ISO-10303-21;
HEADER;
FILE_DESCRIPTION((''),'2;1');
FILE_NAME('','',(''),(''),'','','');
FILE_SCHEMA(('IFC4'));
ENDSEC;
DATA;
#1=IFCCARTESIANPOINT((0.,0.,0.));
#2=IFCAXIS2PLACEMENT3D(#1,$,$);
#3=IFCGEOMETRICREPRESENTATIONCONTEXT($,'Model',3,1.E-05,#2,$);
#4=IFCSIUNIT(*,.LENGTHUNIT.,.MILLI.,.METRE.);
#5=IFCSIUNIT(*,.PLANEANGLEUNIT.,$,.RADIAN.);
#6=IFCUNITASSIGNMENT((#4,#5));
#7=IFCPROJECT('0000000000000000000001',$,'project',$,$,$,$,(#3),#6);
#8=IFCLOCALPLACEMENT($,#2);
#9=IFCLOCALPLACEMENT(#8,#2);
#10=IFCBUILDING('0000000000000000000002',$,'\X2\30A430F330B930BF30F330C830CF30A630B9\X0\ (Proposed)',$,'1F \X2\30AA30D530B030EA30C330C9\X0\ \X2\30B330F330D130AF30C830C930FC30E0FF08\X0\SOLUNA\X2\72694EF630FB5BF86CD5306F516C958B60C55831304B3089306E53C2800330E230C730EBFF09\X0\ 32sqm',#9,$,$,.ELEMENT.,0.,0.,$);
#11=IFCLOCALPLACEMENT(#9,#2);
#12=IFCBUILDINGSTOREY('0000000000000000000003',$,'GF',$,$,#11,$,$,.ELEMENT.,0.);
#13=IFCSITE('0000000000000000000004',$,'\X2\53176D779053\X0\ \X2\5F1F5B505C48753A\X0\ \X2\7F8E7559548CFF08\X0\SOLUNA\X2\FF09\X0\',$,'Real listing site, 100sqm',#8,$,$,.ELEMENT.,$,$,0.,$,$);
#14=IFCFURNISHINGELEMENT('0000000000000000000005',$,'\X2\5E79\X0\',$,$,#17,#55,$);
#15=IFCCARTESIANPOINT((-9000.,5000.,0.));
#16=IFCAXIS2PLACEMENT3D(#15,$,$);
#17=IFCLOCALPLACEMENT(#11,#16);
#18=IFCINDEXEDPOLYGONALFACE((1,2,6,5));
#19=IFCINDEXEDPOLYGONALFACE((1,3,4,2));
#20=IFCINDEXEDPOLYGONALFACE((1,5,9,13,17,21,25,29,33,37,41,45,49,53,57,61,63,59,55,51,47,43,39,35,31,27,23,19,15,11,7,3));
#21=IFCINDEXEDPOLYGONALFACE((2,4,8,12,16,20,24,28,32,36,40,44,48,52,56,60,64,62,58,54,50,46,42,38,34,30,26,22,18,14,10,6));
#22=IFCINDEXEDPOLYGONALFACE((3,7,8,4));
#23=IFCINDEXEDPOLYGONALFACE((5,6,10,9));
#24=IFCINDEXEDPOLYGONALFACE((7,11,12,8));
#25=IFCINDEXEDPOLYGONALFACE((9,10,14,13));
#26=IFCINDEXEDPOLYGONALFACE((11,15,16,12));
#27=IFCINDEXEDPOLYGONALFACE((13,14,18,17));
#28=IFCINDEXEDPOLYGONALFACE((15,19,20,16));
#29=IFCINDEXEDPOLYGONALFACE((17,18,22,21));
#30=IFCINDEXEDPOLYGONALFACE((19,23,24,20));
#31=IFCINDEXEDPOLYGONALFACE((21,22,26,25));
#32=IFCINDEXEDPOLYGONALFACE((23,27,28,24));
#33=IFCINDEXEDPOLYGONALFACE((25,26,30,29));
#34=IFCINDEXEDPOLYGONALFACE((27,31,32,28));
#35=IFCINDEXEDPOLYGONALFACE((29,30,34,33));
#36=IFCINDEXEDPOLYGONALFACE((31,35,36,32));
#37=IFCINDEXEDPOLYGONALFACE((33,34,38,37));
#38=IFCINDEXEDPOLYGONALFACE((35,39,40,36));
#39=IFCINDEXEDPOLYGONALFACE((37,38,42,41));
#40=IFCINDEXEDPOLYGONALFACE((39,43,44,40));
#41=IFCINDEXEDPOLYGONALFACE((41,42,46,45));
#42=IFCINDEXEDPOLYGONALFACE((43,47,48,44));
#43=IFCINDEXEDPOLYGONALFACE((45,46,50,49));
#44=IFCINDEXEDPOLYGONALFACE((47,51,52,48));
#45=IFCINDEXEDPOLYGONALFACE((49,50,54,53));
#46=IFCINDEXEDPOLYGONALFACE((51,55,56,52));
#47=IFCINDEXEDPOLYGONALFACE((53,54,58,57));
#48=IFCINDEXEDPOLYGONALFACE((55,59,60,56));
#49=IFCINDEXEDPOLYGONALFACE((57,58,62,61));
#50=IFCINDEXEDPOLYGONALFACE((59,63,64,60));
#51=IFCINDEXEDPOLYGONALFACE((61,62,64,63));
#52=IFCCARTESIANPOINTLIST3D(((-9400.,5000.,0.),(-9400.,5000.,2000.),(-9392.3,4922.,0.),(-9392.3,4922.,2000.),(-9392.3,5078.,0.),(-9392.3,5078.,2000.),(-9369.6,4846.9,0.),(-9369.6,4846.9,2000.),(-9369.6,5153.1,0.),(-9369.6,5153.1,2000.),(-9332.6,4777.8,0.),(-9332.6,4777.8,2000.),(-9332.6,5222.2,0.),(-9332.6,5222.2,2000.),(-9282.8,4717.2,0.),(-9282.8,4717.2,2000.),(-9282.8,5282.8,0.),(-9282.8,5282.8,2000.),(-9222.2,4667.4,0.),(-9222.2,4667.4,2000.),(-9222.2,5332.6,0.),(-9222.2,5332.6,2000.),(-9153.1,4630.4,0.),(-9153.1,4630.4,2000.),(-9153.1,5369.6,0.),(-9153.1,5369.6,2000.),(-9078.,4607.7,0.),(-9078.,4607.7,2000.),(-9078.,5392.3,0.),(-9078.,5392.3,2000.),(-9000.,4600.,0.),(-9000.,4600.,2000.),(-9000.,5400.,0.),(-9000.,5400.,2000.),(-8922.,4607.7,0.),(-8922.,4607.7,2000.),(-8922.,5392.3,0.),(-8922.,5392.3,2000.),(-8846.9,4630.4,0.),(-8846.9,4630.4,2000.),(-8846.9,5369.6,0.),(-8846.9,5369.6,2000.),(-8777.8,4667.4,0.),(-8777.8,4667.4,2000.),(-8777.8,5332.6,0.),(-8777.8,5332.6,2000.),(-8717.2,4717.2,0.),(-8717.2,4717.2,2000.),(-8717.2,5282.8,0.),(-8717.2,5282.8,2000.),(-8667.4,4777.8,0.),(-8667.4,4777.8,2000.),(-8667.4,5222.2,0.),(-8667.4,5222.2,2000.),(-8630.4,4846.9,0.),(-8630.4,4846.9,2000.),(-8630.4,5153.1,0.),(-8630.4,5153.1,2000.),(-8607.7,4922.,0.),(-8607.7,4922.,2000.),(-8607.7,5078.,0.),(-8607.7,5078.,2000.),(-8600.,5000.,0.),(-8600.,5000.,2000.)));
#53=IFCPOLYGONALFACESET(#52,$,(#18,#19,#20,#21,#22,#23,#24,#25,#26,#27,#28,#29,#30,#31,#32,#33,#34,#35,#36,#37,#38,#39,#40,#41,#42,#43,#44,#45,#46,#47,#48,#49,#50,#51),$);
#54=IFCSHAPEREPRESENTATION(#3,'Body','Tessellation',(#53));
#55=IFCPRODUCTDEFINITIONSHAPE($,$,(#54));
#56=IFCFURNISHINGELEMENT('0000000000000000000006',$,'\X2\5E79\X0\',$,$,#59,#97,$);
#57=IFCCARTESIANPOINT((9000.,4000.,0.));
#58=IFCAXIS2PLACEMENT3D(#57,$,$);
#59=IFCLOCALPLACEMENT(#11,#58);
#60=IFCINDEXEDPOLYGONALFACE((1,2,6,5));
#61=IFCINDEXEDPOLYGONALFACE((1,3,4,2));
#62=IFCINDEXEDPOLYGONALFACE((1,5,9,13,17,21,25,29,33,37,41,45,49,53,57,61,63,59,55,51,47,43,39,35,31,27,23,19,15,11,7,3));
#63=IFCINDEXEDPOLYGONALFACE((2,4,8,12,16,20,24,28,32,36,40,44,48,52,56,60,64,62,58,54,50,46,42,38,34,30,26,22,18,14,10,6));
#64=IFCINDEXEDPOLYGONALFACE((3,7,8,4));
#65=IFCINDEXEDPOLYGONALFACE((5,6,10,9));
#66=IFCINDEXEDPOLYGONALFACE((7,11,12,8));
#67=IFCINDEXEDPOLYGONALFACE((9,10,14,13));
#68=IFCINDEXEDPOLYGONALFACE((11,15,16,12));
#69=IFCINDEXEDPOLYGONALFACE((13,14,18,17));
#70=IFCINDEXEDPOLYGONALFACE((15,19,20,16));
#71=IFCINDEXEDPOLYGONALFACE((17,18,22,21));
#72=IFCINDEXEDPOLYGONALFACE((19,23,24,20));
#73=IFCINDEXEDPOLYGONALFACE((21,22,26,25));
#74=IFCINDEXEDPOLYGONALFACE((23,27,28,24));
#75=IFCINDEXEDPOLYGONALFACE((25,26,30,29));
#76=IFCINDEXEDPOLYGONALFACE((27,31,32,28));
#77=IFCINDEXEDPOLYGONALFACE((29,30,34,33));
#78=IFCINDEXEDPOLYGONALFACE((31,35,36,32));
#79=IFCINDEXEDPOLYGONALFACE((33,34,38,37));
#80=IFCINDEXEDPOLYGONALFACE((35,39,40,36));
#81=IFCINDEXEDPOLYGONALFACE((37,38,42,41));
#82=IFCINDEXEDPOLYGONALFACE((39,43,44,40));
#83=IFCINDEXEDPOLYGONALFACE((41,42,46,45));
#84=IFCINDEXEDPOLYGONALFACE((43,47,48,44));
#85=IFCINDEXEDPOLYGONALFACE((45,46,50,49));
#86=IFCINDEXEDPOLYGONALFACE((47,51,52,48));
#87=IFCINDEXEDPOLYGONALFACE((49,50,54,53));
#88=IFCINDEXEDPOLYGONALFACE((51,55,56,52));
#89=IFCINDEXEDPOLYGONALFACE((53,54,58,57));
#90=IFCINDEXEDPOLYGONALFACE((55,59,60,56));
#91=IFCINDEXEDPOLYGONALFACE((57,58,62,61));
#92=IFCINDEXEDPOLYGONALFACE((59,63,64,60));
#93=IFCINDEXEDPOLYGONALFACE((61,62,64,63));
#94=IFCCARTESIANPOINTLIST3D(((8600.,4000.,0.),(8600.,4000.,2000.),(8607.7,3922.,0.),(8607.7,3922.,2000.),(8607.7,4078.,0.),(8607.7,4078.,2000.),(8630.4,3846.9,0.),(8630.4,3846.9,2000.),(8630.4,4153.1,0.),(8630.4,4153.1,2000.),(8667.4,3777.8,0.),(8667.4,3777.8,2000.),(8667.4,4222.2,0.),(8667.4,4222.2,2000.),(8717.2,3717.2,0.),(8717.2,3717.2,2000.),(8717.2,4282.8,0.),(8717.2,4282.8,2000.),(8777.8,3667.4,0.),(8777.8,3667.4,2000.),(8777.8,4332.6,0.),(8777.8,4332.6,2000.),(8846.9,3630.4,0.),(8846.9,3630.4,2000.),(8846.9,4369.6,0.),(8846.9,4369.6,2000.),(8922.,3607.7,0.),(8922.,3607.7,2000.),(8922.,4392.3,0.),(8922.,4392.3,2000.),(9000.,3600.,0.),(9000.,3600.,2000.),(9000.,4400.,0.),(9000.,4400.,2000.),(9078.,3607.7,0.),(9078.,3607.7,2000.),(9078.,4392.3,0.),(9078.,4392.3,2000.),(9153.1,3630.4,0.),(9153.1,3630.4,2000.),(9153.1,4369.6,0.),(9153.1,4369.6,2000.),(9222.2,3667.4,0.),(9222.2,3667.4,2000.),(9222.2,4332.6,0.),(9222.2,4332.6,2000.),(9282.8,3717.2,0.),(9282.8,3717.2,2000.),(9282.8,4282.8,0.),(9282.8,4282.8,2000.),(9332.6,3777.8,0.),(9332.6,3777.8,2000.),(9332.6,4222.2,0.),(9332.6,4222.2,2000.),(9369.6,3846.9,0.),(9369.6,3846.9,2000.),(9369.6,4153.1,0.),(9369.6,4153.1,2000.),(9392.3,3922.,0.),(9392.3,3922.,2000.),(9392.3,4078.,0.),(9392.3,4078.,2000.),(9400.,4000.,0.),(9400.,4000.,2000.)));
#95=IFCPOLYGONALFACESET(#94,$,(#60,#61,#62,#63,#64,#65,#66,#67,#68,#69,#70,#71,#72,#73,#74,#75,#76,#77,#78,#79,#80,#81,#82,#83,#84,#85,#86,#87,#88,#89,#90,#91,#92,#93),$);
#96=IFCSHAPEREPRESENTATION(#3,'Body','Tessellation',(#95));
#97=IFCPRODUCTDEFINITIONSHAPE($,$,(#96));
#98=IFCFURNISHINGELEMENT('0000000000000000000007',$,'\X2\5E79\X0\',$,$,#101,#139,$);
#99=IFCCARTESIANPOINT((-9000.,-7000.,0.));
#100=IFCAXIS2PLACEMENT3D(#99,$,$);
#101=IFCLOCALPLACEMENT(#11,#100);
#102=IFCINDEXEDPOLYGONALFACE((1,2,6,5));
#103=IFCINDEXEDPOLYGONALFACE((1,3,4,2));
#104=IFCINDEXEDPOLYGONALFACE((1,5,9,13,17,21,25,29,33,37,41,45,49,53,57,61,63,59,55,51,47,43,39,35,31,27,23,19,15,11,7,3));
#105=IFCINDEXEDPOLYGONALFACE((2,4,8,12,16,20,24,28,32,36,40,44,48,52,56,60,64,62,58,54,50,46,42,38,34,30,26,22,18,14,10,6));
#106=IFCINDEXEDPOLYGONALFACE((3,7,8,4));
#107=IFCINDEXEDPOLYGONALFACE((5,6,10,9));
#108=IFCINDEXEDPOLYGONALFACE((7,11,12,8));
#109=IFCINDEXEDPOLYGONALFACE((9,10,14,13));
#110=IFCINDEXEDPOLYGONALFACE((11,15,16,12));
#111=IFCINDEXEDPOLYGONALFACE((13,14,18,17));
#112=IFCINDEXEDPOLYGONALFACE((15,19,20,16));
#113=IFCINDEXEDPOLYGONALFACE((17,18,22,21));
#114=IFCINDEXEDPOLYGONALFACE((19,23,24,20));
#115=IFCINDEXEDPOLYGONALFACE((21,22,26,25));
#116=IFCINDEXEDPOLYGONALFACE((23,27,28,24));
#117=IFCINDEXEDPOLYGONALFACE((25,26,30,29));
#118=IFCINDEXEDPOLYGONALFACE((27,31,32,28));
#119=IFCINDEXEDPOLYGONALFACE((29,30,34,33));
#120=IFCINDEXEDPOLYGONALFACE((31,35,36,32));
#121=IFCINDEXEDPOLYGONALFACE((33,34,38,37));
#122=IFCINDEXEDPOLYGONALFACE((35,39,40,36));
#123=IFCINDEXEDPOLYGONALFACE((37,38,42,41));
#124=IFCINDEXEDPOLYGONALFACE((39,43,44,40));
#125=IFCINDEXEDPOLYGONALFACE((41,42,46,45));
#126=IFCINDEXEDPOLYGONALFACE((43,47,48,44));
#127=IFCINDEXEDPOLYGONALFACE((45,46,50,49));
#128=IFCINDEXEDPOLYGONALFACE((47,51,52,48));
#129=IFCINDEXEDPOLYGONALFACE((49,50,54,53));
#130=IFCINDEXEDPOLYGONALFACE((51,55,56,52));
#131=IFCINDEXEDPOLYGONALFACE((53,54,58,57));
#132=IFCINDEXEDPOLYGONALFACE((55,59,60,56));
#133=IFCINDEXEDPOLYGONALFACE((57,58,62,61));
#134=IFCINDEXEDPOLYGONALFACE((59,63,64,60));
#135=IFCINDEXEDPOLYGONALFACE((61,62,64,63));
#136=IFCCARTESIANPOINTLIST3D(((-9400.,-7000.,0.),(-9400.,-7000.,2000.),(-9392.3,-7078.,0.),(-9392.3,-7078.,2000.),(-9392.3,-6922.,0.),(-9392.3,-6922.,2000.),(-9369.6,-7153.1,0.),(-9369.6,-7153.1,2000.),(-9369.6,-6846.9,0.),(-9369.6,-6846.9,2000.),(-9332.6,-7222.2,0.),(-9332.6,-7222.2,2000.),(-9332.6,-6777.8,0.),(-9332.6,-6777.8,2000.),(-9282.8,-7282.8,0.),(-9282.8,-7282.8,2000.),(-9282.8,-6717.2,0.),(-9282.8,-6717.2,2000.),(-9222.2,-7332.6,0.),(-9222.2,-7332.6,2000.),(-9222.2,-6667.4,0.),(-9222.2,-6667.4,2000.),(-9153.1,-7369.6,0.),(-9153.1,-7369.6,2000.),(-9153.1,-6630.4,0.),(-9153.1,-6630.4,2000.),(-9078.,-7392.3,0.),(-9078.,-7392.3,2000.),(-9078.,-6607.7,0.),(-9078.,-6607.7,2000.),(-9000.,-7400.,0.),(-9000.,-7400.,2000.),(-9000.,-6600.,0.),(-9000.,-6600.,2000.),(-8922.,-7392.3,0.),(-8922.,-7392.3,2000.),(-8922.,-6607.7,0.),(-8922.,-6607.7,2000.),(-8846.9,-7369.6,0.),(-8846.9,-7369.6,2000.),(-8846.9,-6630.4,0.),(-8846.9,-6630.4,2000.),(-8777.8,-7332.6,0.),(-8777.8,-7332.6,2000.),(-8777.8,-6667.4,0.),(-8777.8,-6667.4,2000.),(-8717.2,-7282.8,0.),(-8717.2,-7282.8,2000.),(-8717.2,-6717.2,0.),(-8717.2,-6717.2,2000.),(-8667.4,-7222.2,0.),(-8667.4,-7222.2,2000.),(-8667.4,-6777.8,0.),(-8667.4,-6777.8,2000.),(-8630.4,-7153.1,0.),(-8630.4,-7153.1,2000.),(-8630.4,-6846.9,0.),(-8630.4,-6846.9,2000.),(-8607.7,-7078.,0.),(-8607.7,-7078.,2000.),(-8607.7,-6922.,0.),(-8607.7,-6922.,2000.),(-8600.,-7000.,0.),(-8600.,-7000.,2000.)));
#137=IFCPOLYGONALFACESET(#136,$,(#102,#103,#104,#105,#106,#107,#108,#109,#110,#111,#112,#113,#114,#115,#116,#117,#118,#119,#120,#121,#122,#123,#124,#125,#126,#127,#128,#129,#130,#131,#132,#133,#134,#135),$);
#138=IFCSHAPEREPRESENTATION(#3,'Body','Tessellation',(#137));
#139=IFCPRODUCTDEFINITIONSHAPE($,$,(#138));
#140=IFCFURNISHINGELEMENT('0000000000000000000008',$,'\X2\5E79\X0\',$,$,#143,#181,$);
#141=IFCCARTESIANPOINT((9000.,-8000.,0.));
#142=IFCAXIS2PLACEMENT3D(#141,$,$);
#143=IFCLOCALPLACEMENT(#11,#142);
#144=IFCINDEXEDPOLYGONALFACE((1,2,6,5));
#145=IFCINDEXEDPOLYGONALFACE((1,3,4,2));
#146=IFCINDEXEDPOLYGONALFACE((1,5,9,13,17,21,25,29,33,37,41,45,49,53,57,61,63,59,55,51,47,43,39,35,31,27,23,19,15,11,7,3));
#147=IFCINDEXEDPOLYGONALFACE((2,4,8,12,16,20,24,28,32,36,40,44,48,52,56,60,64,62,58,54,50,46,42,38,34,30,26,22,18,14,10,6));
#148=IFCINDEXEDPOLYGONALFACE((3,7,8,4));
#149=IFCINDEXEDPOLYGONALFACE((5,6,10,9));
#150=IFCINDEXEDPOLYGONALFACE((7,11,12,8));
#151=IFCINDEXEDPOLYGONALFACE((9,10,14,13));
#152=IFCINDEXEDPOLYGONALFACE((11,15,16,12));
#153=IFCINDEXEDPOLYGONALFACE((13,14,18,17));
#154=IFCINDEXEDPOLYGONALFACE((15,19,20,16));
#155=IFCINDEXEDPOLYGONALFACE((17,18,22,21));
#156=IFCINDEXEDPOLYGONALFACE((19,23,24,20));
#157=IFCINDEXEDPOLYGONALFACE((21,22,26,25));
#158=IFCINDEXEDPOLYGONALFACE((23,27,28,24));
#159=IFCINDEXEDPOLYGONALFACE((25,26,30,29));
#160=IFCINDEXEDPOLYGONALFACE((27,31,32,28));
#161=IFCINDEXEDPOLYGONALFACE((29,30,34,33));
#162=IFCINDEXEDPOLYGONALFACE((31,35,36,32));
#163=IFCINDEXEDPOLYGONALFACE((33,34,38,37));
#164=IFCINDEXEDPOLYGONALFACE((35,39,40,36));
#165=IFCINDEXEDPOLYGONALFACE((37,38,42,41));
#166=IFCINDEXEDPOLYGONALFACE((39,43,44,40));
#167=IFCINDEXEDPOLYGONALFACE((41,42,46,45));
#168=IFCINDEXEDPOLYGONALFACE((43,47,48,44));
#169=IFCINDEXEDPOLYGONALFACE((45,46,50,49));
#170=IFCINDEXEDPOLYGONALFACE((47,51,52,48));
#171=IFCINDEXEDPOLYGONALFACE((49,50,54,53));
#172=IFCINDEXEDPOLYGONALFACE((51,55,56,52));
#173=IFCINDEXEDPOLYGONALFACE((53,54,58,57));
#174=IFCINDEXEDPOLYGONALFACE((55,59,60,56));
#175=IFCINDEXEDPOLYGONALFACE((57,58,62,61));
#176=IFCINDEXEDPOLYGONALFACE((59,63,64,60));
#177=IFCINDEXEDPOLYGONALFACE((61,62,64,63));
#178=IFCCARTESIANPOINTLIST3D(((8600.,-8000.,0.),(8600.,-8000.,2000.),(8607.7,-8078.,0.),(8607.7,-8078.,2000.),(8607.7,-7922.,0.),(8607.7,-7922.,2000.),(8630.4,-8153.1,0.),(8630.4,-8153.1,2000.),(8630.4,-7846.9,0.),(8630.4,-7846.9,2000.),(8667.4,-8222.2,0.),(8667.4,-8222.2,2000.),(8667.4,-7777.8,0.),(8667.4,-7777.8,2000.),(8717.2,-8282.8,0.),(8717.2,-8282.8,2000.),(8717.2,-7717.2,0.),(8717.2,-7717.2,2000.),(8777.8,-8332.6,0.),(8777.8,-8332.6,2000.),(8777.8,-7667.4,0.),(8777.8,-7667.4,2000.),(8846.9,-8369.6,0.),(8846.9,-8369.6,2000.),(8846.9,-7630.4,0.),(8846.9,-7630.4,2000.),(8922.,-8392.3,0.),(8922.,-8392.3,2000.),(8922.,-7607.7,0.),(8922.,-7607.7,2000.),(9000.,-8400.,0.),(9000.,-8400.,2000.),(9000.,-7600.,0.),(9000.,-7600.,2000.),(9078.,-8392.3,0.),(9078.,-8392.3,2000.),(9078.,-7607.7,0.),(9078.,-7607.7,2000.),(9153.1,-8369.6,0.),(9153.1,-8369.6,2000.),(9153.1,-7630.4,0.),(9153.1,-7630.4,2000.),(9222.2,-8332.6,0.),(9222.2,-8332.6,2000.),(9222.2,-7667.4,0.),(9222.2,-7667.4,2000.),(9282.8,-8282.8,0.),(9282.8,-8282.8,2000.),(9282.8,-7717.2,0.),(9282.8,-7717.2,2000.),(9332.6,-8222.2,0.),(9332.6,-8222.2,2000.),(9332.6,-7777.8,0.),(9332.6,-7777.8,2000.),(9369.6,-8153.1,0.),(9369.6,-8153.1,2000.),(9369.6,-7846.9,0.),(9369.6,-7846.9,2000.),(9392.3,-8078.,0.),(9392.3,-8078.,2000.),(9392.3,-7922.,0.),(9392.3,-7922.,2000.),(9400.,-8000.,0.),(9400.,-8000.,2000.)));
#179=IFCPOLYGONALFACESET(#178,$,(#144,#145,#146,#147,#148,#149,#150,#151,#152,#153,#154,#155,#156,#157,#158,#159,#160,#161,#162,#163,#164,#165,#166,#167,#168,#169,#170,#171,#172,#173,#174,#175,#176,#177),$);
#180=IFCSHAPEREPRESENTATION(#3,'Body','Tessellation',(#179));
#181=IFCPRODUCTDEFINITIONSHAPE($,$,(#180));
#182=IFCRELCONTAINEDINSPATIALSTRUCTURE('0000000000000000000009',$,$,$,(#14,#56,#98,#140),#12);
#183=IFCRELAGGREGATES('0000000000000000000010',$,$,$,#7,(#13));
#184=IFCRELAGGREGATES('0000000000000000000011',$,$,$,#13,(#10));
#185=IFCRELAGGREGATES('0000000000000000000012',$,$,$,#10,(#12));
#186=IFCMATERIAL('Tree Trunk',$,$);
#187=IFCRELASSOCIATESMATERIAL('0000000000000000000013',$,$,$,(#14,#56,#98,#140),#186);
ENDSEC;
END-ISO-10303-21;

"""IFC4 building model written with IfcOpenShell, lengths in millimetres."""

from ifc_helpers import new_model, si_unit, frame, origin, origin_2d, place, context, project, spatial, circle, extrude, material, element, save


model = new_model("IFC4")

# Units and contexts
model_context = context("Model", 3, precision=1e-05, world=origin())
ifc_project = project(units=[si_unit("LENGTHUNIT", "METRE", prefix="MILLI"), si_unit("PLANEANGLEUNIT", "RADIAN")], contexts=[model_context])

# Site, building, storey
site_placement = place(None, origin())
site = spatial("IfcSite", under=ifc_project, at=site_placement, Name="北海道 弟子屈町 美留和（SOLUNA）", ObjectType="Real listing site, 100sqm", CompositionType="ELEMENT", RefElevation=0.0)
building_placement = place(site_placement, origin())
building = spatial("IfcBuilding", under=site, at=building_placement, Name="インスタントハウス (Proposed)", ObjectType="1F オフグリッド コンパクトドーム（SOLUNA物件・寸法は公開情報からの参考モデル） 32sqm", CompositionType="ELEMENT", ElevationOfRefHeight=0.0, ElevationOfTerrain=0.0)
storey_placement = place(building_placement, origin())
storey = spatial("IfcBuildingStorey", under=building, at=storey_placement, Name="GF", CompositionType="ELEMENT", Elevation=0.0)

# Furnishing elements
ifc_material_1 = material(Name="Tree Trunk")
furnishing_1_placement = place(storey_placement, frame((-9000.0, 5000.0, 0.0)))
element("IfcFurnishingElement", 1, at=furnishing_1_placement, inside=storey, material=ifc_material_1, Name="幹", context=model_context, shape_type="SweptSolid", body=[
    extrude(circle(Radius=400.0, at=origin_2d()), frame((-9000.0, 5000.0, 0.0)), (0.0, 0.0, 1.0), 2000.0),
])
furnishing_2_placement = place(storey_placement, frame((9000.0, 4000.0, 0.0)))
element("IfcFurnishingElement", 2, at=furnishing_2_placement, inside=storey, material=ifc_material_1, Name="幹", context=model_context, shape_type="SweptSolid", body=[
    extrude(circle(Radius=400.0, at=origin_2d()), frame((9000.0, 4000.0, 0.0)), (0.0, 0.0, 1.0), 2000.0),
])
furnishing_3_placement = place(storey_placement, frame((-9000.0, -7000.0, 0.0)))
element("IfcFurnishingElement", 3, at=furnishing_3_placement, inside=storey, material=ifc_material_1, Name="幹", context=model_context, shape_type="SweptSolid", body=[
    extrude(circle(Radius=400.0, at=origin_2d()), frame((-9000.0, -7000.0, 0.0)), (0.0, 0.0, 1.0), 2000.0),
])
furnishing_4_placement = place(storey_placement, frame((9000.0, -8000.0, 0.0)))
element("IfcFurnishingElement", 4, at=furnishing_4_placement, inside=storey, material=ifc_material_1, Name="幹", context=model_context, shape_type="SweptSolid", body=[
    extrude(circle(Radius=400.0, at=origin_2d()), frame((9000.0, -8000.0, 0.0)), (0.0, 0.0, 1.0), 2000.0),
])

save(model, "model.ifc")
